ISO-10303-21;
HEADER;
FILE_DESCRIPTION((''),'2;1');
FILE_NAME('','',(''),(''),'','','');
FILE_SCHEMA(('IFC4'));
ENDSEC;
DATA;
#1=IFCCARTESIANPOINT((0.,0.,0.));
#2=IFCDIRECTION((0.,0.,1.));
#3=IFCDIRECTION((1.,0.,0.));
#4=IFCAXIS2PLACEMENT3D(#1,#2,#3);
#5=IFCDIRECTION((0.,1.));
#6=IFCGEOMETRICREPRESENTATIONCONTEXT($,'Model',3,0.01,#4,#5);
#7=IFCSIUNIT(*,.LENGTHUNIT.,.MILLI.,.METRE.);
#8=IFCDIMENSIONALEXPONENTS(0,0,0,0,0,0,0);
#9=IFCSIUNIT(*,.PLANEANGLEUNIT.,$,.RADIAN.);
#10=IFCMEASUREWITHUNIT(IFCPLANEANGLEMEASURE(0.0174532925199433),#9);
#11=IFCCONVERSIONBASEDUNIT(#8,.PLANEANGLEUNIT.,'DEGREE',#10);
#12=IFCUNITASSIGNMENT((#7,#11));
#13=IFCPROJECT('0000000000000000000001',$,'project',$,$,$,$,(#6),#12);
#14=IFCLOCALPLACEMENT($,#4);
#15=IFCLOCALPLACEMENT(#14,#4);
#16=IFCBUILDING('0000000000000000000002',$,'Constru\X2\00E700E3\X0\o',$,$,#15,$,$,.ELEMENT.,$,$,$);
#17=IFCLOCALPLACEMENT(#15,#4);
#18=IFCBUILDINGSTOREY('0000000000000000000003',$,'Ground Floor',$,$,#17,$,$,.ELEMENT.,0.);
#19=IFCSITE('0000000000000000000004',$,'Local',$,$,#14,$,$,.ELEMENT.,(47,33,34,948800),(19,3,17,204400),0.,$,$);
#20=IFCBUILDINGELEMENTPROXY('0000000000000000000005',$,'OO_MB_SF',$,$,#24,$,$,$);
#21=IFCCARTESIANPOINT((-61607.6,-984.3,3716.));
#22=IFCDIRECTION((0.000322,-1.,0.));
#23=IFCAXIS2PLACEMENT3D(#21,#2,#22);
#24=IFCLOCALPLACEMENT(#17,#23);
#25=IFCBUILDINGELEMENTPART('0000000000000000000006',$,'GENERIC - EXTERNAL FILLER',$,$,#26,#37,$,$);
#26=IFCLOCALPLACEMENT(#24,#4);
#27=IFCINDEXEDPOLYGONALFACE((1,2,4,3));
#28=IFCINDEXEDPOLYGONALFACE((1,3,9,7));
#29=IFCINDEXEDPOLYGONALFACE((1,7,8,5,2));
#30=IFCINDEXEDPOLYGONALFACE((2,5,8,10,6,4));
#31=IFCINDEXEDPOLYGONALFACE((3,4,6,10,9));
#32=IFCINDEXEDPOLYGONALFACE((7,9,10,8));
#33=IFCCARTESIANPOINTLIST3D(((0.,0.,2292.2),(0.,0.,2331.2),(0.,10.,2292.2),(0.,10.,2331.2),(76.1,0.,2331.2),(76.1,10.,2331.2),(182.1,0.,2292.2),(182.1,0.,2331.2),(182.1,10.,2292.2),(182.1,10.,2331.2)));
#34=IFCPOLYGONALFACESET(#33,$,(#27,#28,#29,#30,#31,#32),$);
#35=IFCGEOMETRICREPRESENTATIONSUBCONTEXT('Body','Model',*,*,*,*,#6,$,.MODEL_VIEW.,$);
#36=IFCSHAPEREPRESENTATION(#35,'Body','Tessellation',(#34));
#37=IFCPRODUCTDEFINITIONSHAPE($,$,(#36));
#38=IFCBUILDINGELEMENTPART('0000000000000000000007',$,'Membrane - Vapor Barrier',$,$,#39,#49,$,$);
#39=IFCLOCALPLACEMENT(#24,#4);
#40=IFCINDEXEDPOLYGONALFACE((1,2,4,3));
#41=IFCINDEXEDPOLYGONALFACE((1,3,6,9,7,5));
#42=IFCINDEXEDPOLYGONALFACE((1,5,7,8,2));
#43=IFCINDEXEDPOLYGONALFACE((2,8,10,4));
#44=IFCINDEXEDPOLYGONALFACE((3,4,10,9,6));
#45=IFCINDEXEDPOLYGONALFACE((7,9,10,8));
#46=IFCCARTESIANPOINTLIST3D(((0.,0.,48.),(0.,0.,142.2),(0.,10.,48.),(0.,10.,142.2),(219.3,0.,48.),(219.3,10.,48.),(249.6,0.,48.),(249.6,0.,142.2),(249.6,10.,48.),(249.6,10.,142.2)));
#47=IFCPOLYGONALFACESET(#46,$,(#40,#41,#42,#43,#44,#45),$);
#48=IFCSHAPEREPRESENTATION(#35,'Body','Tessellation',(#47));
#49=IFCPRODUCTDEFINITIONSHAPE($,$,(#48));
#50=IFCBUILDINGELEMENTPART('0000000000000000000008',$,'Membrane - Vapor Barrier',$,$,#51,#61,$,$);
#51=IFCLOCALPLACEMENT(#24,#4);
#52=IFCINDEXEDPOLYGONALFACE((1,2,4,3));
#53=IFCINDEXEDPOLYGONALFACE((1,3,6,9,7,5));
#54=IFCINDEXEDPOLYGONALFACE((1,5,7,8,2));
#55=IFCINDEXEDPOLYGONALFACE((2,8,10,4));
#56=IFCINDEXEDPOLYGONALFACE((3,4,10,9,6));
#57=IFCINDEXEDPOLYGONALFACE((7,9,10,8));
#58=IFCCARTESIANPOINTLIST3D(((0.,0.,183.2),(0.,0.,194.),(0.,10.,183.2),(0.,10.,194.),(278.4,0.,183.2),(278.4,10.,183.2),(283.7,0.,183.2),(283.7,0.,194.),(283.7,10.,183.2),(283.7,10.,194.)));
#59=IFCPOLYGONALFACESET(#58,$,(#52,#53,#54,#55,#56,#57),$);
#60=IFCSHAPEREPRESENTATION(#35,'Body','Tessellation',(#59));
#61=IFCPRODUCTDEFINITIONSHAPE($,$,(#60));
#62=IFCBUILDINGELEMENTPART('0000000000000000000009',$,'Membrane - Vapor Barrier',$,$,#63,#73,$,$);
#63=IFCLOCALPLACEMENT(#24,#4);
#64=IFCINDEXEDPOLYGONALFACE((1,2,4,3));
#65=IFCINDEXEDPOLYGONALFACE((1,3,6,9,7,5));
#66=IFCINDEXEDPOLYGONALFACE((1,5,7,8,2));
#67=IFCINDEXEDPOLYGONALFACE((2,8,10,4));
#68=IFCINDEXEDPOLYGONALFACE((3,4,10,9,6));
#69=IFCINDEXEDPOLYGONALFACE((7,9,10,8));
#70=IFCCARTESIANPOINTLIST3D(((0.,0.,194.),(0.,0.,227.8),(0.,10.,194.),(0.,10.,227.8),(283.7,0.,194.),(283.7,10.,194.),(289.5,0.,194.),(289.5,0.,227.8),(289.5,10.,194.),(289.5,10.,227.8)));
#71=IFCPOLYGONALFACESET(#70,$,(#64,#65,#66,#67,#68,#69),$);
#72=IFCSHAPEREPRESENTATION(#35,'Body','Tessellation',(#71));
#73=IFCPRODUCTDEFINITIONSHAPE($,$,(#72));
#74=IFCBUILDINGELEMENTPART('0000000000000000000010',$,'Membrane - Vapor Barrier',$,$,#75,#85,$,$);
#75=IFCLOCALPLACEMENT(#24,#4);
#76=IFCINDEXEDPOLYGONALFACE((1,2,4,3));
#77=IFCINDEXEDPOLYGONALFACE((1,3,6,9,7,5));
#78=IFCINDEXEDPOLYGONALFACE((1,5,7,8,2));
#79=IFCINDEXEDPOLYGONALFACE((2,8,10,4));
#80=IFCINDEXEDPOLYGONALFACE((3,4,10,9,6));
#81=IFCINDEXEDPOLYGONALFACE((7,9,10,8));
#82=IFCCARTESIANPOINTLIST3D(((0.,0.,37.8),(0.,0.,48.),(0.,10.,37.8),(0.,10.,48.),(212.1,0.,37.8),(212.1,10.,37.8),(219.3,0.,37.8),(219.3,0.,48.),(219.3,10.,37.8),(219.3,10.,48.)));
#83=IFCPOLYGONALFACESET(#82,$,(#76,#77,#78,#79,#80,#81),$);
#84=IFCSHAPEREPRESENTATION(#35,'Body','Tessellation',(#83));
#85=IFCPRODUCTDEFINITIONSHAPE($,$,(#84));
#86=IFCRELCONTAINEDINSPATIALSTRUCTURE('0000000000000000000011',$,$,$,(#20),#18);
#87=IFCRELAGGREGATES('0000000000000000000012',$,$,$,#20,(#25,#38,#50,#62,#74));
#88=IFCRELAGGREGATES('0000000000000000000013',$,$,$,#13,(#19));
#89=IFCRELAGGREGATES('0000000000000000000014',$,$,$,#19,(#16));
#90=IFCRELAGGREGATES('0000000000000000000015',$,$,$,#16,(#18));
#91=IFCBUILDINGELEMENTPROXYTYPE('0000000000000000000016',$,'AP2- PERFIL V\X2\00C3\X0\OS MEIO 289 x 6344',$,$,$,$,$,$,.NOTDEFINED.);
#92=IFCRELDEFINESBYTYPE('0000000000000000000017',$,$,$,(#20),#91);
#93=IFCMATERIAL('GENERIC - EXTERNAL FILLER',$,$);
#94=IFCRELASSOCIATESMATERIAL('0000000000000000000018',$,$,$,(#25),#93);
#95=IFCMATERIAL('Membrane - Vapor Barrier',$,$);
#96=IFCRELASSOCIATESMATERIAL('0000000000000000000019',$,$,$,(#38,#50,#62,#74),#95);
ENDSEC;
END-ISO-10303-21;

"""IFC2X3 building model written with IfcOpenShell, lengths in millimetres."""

from ifc_helpers import new_model, entity, si_unit, converted_unit, direction, frame, origin_with_axes, place, context, subcontext, project, spatial, polyline, outline, extrude, material, type_object, element, aggregate, save


model = new_model("IFC2X3")

# Units and contexts
model_context = context("Model", 3, precision=0.01, world=origin_with_axes(), true_north=direction((0.0, 1.0)))
body_context = subcontext(model_context, "Body", "Model", "MODEL_VIEW")
ifc_project = project(units=[si_unit("LENGTHUNIT", "METRE", prefix="MILLI"), converted_unit("PLANEANGLEUNIT", "DEGREE", entity("IfcPlaneAngleMeasure", 0.0174532925199433), si_unit("PLANEANGLEUNIT", "RADIAN"), dimensions=[0, 0, 0, 0, 0, 0, 0])], contexts=[model_context])

# Site, building, storey
site_placement = place(None, origin_with_axes())
site = spatial("IfcSite", under=ifc_project, at=site_placement, Name="Local", CompositionType="ELEMENT", RefLatitude=(47, 33, 34, 948800), RefLongitude=(19, 3, 17, 204400), RefElevation=0.0)
building_placement = place(site_placement, origin_with_axes())
building = spatial("IfcBuilding", under=site, at=building_placement, Name="Construção", CompositionType="ELEMENT")
storey_placement = place(building_placement, origin_with_axes())
storey = spatial("IfcBuildingStorey", under=building, at=storey_placement, Name="Ground Floor", CompositionType="ELEMENT", Elevation=0.0)

# Building element proxy, building element parts
building_element_proxy_type_1 = type_object("IfcBuildingElementProxyType", Name="AP2- PERFIL VÃOS MEIO 289 x 6344", PredefinedType="NOTDEFINED")
ifc_material_1 = material(Name="Membrane - Vapor Barrier")
ifc_material_2 = material(Name="GENERIC - EXTERNAL FILLER")
proxy_1_placement = place(storey_placement, frame((-61607.6, -984.3, 3716.0), z_axis=(0.0, 0.0, 1.0), x_axis=(0.000322, -1.0, 0.0)))
proxy_1 = element("IfcBuildingElementProxy", 1, at=proxy_1_placement, inside=storey, type_object=building_element_proxy_type_1, Name="OO_MB_SF")
building_element_part_1_placement = place(proxy_1_placement, origin_with_axes())
building_element_part_1 = element("IfcBuildingElementPart", 2, at=building_element_part_1_placement, material=ifc_material_2, Name="GENERIC - EXTERNAL FILLER", context=body_context, shape_type="SweptSolid", body=[
    extrude(outline(polyline([(0.0, 2331.2), (0.0, 2292.2), (182.1, 2292.2), (182.1, 2331.2), (76.1, 2331.2), (0.0, 2331.2)])), frame((0.0, 10.0, 0.0), z_axis=(0.0, -1.0, 0.0), x_axis=(1.0, 0.0, 0.0)), (0.0, 0.0, 1.0), 10.0),
])
building_element_part_2_placement = place(proxy_1_placement, origin_with_axes())
building_element_part_2 = element("IfcBuildingElementPart", 3, at=building_element_part_2_placement, material=ifc_material_1, Name="Membrane - Vapor Barrier", context=body_context, shape_type="SweptSolid", body=[
    extrude(outline(polyline([(249.6, 142.2), (0.0, 142.2), (0.0, 48.0), (219.3, 48.0), (249.6, 48.0), (249.6, 142.2)])), frame((0.0, 10.0, 0.0), z_axis=(0.0, -1.0, 0.0), x_axis=(1.0, 0.0, 0.0)), (0.0, 0.0, 1.0), 10.0),
])
building_element_part_3_placement = place(proxy_1_placement, origin_with_axes())
building_element_part_3 = element("IfcBuildingElementPart", 4, at=building_element_part_3_placement, material=ifc_material_1, Name="Membrane - Vapor Barrier", context=body_context, shape_type="SweptSolid", body=[
    extrude(outline(polyline([(0.0, 183.2), (278.4, 183.2), (283.7, 183.2), (283.7, 194.0), (0.0, 194.0), (0.0, 183.2)])), frame((0.0, 10.0, 0.0), z_axis=(0.0, -1.0, 0.0), x_axis=(1.0, 0.0, 0.0)), (0.0, 0.0, 1.0), 10.0),
])
building_element_part_4_placement = place(proxy_1_placement, origin_with_axes())
building_element_part_4 = element("IfcBuildingElementPart", 5, at=building_element_part_4_placement, material=ifc_material_1, Name="Membrane - Vapor Barrier", context=body_context, shape_type="SweptSolid", body=[
    extrude(outline(polyline([(0.0, 194.0), (283.7, 194.0), (289.5, 194.0), (289.5, 227.8), (0.0, 227.8), (0.0, 194.0)])), frame((0.0, 10.0, 0.0), z_axis=(0.0, -1.0, 0.0), x_axis=(1.0, 0.0, 0.0)), (0.0, 0.0, 1.0), 10.0),
])
building_element_part_5_placement = place(proxy_1_placement, origin_with_axes())
building_element_part_5 = element("IfcBuildingElementPart", 6, at=building_element_part_5_placement, material=ifc_material_1, Name="Membrane - Vapor Barrier", context=body_context, shape_type="SweptSolid", body=[
    extrude(outline(polyline([(0.0, 37.8), (212.1, 37.8), (219.3, 37.8), (219.3, 48.0), (0.0, 48.0), (0.0, 37.8)])), frame((0.0, 10.0, 0.0), z_axis=(0.0, -1.0, 0.0), x_axis=(1.0, 0.0, 0.0)), (0.0, 0.0, 1.0), 10.0),
])
aggregate(proxy_1, [building_element_part_1, building_element_part_2, building_element_part_3, building_element_part_4, building_element_part_5])

save(model, "model.ifc")
